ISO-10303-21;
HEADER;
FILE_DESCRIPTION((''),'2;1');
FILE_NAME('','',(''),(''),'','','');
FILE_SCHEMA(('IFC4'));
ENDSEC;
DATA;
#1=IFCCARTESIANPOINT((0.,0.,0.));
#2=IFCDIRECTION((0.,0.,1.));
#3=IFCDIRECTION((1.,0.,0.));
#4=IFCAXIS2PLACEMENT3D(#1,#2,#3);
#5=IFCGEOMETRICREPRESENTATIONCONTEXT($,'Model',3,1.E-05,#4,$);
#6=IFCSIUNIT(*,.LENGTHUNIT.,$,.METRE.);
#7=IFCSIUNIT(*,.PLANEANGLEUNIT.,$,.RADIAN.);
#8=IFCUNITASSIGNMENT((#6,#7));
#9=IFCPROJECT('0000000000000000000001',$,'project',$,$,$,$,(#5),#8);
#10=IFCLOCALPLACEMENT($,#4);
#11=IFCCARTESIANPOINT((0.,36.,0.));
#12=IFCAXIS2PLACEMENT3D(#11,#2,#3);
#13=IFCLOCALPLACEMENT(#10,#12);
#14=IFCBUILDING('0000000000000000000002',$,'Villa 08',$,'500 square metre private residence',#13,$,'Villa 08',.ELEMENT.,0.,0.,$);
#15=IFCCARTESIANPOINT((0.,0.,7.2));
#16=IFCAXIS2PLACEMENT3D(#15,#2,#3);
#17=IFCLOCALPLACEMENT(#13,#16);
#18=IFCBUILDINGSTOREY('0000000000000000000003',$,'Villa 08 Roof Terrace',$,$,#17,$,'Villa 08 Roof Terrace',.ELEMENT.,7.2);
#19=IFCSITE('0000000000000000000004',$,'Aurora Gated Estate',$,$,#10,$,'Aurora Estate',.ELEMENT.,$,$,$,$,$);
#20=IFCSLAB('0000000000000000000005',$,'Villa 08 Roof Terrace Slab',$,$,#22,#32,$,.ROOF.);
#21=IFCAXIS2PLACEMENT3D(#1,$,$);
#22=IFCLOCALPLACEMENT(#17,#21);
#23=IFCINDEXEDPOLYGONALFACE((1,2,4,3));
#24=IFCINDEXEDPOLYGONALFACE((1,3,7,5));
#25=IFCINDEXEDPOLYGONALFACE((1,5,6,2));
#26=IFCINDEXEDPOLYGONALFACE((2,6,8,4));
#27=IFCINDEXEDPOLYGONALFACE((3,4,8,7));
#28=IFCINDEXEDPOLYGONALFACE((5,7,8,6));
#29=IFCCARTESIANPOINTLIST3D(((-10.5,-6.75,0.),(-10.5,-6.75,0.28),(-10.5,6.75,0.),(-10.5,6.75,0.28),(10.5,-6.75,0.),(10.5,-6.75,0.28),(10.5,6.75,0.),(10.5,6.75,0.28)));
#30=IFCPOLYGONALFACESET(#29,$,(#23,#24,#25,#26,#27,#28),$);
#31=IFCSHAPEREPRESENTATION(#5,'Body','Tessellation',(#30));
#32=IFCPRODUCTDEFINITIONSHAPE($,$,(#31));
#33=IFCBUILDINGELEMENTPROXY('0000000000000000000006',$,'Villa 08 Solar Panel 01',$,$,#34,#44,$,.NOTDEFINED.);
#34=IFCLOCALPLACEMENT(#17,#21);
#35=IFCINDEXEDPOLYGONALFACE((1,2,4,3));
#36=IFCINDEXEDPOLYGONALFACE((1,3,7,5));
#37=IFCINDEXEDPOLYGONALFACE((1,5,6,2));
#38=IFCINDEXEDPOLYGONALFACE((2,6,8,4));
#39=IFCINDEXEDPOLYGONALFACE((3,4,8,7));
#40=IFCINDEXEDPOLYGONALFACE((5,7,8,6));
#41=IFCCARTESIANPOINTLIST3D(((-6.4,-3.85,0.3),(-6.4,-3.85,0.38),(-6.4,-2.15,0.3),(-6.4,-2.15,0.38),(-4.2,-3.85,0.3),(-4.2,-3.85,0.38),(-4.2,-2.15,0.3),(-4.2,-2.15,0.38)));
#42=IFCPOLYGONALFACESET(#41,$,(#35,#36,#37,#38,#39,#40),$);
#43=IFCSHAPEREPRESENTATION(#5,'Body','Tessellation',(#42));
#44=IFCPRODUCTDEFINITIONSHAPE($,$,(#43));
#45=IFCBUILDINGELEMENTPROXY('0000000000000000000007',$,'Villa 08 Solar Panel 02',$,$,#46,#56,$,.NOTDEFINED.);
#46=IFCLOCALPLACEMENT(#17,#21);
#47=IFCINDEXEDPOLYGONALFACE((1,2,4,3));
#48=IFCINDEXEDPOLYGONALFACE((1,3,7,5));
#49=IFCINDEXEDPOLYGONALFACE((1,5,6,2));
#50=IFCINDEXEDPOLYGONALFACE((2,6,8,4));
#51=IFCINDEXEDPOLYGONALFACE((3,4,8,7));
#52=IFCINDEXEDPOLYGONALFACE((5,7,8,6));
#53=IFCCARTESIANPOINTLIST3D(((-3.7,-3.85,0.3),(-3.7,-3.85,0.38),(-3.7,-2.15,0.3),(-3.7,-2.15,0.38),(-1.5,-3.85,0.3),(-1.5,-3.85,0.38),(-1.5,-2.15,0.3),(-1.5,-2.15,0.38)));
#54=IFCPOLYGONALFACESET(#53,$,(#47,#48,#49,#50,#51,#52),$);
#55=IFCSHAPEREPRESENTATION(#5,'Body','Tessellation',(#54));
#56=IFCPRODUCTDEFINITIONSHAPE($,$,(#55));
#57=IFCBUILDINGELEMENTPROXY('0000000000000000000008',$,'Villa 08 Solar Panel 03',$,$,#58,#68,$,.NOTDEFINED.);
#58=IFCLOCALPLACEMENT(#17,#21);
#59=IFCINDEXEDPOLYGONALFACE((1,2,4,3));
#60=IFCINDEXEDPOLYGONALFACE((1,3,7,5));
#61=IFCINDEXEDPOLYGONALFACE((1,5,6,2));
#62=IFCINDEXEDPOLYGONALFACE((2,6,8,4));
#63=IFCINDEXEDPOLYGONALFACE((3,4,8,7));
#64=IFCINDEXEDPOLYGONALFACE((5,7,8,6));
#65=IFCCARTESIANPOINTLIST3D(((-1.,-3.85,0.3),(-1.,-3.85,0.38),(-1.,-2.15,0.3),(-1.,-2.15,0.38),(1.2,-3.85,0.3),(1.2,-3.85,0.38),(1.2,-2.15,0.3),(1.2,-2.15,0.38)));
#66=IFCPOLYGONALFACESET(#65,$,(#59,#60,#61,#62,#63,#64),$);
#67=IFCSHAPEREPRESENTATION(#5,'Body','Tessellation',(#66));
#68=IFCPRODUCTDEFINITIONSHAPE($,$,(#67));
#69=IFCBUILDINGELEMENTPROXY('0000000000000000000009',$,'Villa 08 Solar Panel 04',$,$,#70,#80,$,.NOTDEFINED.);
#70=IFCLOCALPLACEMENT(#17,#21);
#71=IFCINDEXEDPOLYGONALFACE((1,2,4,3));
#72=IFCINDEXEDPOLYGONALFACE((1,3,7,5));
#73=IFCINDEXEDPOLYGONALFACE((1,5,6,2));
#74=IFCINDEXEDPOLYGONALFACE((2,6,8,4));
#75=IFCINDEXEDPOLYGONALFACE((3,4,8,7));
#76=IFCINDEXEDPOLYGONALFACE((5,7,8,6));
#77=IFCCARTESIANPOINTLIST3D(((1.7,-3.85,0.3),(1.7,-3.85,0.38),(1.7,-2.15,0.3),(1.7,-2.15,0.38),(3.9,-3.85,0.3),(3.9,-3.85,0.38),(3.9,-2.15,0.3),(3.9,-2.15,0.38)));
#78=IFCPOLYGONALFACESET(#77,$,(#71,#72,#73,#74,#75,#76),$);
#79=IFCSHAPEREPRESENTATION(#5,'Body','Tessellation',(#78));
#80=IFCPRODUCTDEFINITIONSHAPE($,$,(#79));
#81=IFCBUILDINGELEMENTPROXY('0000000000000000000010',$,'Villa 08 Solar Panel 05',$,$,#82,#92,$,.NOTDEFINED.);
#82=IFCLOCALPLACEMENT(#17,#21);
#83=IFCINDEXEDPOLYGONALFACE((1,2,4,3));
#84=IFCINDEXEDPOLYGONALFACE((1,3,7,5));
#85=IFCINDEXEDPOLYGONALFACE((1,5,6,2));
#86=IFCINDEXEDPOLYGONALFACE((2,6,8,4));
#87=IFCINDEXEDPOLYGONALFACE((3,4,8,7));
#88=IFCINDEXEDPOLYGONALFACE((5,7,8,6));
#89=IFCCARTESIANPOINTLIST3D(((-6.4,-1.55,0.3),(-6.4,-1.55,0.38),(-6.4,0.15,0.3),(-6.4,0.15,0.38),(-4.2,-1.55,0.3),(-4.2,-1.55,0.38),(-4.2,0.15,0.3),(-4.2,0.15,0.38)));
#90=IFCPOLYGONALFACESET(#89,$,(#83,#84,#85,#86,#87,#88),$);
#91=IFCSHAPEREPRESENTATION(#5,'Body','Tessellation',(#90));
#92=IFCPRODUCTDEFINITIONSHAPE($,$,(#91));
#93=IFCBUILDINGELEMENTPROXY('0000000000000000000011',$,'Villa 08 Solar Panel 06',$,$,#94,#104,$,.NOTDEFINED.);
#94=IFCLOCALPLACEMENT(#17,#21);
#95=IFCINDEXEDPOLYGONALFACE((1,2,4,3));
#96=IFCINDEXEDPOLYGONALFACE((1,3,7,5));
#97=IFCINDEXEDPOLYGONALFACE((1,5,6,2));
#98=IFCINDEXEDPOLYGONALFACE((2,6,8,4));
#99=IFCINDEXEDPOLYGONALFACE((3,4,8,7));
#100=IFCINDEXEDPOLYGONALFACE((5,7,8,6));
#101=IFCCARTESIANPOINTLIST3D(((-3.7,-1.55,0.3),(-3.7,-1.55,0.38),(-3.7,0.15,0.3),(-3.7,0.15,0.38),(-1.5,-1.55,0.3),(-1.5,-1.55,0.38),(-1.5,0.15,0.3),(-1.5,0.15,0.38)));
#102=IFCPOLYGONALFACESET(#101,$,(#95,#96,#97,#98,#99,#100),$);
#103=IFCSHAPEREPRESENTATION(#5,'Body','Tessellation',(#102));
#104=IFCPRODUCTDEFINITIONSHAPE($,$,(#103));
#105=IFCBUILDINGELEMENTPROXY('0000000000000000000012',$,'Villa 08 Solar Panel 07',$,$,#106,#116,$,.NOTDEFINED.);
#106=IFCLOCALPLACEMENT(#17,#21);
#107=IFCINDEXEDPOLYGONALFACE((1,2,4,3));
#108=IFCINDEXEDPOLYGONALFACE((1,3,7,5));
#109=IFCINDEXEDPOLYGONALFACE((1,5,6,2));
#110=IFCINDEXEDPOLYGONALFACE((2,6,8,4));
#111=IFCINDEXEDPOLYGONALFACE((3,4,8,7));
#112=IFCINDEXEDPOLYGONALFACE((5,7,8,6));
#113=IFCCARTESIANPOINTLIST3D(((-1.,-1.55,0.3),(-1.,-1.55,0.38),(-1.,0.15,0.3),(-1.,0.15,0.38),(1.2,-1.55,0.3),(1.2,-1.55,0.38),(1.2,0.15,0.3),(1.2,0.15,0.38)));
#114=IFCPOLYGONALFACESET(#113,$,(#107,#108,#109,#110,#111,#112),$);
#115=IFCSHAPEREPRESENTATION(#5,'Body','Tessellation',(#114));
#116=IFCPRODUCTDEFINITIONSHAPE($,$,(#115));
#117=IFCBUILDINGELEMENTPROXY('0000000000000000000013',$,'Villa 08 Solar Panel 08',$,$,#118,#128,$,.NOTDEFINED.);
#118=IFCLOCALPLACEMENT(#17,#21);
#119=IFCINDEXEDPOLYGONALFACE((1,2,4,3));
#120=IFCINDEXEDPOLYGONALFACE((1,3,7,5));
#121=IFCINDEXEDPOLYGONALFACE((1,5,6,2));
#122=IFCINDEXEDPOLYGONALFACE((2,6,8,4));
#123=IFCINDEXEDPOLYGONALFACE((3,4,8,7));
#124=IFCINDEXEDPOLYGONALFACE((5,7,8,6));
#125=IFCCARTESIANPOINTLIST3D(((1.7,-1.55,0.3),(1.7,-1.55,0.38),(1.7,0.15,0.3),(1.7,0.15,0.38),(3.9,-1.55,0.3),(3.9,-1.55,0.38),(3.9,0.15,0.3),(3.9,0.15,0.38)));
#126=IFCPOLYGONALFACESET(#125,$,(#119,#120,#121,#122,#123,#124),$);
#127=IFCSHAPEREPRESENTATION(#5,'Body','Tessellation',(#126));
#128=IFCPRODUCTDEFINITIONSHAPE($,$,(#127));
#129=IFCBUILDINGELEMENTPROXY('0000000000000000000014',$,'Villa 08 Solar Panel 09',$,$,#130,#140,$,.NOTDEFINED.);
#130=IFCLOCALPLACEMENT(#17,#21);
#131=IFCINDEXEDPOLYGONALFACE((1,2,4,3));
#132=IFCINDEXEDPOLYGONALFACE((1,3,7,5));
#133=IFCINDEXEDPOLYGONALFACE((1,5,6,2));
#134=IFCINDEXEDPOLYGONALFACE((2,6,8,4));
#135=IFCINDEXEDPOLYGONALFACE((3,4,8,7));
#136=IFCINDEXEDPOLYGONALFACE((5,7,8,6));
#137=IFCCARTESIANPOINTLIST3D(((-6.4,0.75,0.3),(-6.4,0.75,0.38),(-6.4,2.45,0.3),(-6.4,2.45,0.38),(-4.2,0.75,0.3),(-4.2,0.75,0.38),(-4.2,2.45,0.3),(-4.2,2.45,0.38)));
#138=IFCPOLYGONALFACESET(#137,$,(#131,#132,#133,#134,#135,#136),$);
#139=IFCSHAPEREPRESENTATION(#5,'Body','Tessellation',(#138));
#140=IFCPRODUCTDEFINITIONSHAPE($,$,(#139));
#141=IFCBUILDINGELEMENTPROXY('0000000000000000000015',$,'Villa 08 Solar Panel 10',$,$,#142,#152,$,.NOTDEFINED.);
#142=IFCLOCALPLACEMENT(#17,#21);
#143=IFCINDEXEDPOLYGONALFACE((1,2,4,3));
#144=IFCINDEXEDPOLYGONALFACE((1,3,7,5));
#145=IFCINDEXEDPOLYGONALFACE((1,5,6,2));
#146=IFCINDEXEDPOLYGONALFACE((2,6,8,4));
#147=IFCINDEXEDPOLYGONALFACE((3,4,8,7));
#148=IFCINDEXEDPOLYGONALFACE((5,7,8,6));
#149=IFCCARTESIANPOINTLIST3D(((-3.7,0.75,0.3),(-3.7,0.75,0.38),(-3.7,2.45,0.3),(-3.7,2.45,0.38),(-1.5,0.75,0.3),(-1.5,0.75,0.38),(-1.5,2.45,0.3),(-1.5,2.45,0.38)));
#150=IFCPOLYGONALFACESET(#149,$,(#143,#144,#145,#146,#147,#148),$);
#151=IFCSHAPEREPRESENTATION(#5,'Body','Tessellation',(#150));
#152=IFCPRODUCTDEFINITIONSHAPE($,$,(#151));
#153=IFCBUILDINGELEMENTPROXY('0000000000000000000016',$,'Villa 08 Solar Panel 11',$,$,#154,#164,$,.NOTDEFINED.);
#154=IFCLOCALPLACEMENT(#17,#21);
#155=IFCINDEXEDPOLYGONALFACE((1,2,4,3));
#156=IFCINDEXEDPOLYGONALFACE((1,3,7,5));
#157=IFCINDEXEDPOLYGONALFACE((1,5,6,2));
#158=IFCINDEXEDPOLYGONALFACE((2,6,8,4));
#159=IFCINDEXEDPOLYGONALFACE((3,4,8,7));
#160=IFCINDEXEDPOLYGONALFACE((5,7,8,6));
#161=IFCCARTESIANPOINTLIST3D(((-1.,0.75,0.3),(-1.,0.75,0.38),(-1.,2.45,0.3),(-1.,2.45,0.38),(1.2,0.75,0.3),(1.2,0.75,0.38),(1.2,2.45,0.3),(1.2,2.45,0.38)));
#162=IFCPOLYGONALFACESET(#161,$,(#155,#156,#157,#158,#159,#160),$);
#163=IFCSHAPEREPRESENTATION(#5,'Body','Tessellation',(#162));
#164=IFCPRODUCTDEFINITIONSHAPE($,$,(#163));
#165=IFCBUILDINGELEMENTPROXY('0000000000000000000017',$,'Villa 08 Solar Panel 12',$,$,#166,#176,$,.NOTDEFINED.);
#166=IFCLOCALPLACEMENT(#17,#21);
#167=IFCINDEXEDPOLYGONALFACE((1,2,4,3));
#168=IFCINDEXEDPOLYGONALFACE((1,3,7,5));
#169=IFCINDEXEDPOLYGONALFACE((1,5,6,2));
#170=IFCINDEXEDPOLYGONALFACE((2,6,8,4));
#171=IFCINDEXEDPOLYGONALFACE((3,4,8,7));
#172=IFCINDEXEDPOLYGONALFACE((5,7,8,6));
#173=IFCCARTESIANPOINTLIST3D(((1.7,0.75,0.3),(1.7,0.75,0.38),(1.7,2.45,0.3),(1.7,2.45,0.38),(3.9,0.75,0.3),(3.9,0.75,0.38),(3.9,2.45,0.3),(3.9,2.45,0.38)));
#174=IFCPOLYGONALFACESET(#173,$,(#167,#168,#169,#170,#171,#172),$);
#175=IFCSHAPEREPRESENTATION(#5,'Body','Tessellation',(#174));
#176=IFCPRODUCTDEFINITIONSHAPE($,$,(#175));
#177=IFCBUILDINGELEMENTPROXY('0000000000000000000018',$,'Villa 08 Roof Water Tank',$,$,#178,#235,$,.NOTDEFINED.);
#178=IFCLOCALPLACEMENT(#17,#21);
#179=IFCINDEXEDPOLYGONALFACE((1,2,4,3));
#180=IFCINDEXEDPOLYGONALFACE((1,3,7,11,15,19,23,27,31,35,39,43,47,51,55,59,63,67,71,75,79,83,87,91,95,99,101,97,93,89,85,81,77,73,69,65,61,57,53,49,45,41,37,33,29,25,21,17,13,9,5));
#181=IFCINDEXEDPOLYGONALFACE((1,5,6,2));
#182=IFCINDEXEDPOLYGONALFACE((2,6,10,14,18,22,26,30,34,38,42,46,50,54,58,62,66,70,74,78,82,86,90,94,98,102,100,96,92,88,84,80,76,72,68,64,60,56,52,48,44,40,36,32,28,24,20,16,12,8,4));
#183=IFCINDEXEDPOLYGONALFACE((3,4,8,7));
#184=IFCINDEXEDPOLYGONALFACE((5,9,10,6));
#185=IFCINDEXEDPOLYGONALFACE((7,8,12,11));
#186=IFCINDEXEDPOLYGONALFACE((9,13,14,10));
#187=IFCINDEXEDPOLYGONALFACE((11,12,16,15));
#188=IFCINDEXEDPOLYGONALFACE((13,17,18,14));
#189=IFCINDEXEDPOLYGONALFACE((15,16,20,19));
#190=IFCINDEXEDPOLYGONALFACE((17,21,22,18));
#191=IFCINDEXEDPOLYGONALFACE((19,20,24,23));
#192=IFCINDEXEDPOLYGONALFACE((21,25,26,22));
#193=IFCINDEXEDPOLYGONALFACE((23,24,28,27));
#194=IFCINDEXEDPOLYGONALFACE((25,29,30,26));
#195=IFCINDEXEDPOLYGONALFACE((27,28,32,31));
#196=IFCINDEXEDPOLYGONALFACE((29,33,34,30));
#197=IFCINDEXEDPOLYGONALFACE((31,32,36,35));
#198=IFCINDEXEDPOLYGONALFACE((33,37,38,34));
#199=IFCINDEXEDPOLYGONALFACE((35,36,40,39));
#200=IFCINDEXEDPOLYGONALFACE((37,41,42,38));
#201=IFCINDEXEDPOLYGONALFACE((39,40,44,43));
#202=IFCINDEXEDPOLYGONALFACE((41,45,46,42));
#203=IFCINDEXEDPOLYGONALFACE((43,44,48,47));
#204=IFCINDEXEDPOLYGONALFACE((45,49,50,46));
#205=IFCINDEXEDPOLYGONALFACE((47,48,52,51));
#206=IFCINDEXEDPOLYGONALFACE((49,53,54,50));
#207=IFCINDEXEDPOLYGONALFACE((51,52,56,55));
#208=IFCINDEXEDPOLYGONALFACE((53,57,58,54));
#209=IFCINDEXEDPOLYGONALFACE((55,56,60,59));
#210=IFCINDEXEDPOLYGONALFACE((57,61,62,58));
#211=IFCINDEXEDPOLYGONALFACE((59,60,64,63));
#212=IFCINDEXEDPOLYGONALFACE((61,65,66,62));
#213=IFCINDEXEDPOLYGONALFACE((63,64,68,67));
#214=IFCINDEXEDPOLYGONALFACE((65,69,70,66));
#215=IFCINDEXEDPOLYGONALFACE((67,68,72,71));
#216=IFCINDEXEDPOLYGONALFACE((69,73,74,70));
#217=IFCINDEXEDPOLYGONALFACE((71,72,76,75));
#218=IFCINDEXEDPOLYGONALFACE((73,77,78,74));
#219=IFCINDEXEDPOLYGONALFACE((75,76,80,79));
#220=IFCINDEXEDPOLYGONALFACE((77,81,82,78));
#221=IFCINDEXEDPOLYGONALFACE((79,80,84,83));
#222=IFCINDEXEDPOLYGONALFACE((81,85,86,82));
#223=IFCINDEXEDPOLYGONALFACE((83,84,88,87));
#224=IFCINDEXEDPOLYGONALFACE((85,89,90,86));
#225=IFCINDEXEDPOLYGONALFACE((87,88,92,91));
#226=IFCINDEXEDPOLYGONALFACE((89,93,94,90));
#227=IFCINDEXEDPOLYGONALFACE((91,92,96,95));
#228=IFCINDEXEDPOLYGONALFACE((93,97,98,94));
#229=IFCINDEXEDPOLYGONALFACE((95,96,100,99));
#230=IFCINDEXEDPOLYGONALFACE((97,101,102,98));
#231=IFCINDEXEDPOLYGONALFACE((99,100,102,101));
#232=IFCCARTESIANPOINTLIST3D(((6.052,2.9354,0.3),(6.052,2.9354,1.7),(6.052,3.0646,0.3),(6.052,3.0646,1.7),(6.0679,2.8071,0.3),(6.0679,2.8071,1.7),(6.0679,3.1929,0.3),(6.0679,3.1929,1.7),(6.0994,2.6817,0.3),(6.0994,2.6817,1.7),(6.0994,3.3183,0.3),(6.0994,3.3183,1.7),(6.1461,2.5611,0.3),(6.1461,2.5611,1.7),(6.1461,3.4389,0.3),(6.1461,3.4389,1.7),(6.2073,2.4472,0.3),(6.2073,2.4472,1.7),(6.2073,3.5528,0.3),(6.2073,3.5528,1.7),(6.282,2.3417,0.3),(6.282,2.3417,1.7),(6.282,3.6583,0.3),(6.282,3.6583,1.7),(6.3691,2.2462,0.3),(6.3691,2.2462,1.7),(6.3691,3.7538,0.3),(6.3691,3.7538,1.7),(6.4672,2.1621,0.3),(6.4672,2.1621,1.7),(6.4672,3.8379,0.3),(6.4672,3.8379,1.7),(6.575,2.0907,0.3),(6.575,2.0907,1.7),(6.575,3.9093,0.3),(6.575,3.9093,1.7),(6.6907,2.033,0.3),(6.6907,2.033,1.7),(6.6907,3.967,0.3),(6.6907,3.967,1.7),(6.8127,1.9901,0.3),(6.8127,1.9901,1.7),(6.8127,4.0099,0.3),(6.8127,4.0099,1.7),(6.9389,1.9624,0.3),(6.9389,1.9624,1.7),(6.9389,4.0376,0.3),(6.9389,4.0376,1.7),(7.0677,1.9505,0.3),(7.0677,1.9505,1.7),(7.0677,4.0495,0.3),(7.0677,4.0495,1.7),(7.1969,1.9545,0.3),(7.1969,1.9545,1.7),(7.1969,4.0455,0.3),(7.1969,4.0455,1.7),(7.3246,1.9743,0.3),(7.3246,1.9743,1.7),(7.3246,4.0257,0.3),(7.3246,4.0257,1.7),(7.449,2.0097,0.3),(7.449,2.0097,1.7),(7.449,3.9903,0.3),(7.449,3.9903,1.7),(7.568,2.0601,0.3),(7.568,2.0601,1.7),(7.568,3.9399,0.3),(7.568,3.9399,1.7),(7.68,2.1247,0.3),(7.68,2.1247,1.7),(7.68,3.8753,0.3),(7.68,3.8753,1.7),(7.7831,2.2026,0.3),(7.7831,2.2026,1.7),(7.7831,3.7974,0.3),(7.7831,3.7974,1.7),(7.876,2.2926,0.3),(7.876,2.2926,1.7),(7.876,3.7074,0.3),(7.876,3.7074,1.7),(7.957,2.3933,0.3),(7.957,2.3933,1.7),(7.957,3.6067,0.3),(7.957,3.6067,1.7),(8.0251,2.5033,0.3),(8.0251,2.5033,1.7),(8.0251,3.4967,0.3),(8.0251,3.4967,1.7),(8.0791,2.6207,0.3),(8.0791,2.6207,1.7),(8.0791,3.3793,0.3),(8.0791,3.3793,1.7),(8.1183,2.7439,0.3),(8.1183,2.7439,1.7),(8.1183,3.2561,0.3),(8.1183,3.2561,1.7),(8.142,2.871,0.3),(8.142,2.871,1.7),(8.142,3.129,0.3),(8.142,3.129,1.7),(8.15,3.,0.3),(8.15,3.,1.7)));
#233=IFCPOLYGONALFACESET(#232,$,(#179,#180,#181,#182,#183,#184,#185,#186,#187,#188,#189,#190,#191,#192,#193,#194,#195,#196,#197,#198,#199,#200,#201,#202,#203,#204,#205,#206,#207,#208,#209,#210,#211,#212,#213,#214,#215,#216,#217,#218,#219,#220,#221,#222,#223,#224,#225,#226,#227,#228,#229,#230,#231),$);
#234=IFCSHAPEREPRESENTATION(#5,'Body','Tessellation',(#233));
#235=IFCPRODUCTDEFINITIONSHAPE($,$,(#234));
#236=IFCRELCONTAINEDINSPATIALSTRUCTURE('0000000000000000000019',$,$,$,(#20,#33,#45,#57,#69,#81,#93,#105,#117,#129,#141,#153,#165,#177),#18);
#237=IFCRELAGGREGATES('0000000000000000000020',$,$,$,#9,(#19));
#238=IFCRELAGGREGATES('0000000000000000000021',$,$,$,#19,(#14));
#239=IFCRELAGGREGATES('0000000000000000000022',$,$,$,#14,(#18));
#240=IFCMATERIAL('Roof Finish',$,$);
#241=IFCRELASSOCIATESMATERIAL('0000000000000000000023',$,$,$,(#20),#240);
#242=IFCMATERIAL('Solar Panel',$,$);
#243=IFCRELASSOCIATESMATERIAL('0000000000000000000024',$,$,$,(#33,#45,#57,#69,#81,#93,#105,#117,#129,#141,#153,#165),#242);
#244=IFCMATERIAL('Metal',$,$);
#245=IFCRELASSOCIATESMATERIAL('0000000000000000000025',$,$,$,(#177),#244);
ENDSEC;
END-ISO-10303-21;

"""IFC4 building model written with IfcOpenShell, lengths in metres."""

from ifc_helpers import new_model, si_unit, frame, origin_with_axes, origin_2d_with_axis, place, context, project, spatial, rectangle, circle, extrude, material, element, save


model = new_model("IFC4")

# Units and contexts
model_context = context("Model", 3, precision=1e-05, world=origin_with_axes())
ifc_project = project(units=[si_unit("LENGTHUNIT", "METRE"), si_unit("PLANEANGLEUNIT", "RADIAN")], contexts=[model_context])

# Site, building, storey
site_placement = place(None, origin_with_axes())
site = spatial("IfcSite", under=ifc_project, at=site_placement, Name="Aurora Gated Estate", LongName="Aurora Estate", CompositionType="ELEMENT")
building_placement = place(site_placement, frame((0.0, 36.0, 0.0), z_axis=(0.0, 0.0, 1.0), x_axis=(1.0, 0.0, 0.0)))
building = spatial("IfcBuilding", under=site, at=building_placement, Name="Villa 08", ObjectType="500 square metre private residence", LongName="Villa 08", CompositionType="ELEMENT", ElevationOfRefHeight=0.0, ElevationOfTerrain=0.0)
storey_placement = place(building_placement, frame((0.0, 0.0, 7.2), z_axis=(0.0, 0.0, 1.0), x_axis=(1.0, 0.0, 0.0)))
storey = spatial("IfcBuildingStorey", under=building, at=storey_placement, Name="Villa 08 Roof Terrace", LongName="Villa 08 Roof Terrace", CompositionType="ELEMENT", Elevation=7.2)

# Slab
ifc_material_1 = material(Name="Roof Finish")
slab_placement = place(storey_placement, origin_with_axes())
element("IfcSlab", 1, at=slab_placement, inside=storey, material=ifc_material_1, Name="Villa 08 Roof Terrace Slab", PredefinedType="ROOF", context=model_context, shape_type="SweptSolid", body=[
    extrude(rectangle(XDim=21.0, YDim=13.5, at=origin_2d_with_axis()), origin_with_axes(), (0.0, 0.0, 1.0), 0.28),
])

# Building element proxies
ifc_material_2 = material(Name="Solar Panel")
for number, where, z_axis, x_axis, name in (
    (2, (-5.3, -3.0, 0.3), (0.0, 0.0, 1.0), (1.0, 0.0, 0.0), "Villa 08 Solar Panel 01"),
    (3, (-2.6, -3.0, 0.3), (0.0, 0.0, 1.0), (1.0, 0.0, 0.0), "Villa 08 Solar Panel 02"),
    (4, (0.1, -3.0, 0.3), (0.0, 0.0, 1.0), (1.0, 0.0, 0.0), "Villa 08 Solar Panel 03"),
    (5, (2.8, -3.0, 0.3), (0.0, 0.0, 1.0), (1.0, 0.0, 0.0), "Villa 08 Solar Panel 04"),
    (6, (-5.3, -0.7, 0.3), (0.0, 0.0, 1.0), (1.0, 0.0, 0.0), "Villa 08 Solar Panel 05"),
    (7, (-2.6, -0.7, 0.3), (0.0, 0.0, 1.0), (1.0, 0.0, 0.0), "Villa 08 Solar Panel 06"),
    (8, (0.1, -0.7, 0.3), (0.0, 0.0, 1.0), (1.0, 0.0, 0.0), "Villa 08 Solar Panel 07"),
    (9, (2.8, -0.7, 0.3), (0.0, 0.0, 1.0), (1.0, 0.0, 0.0), "Villa 08 Solar Panel 08"),
    (10, (-5.3, 1.6, 0.3), (0.0, 0.0, 1.0), (1.0, 0.0, 0.0), "Villa 08 Solar Panel 09"),
    (11, (-2.6, 1.6, 0.3), (0.0, 0.0, 1.0), (1.0, 0.0, 0.0), "Villa 08 Solar Panel 10"),
    (12, (0.1, 1.6, 0.3), (0.0, 0.0, 1.0), (1.0, 0.0, 0.0), "Villa 08 Solar Panel 11"),
    (13, (2.8, 1.6, 0.3), (0.0, 0.0, 1.0), (1.0, 0.0, 0.0), "Villa 08 Solar Panel 12"),
):
    element("IfcBuildingElementProxy", number, at=place(storey_placement, frame(where, z_axis=z_axis, x_axis=x_axis)), inside=storey, material=ifc_material_2, Name=name, PredefinedType="NOTDEFINED", context=model_context, shape_type="SweptSolid", body=[
        extrude(rectangle(XDim=2.2, YDim=1.7, at=origin_2d_with_axis()), origin_with_axes(), (0.0, 0.0, 1.0), 0.08),
    ])
ifc_material_3 = material(Name="Metal")
proxy_1_placement = place(storey_placement, frame((7.1, 3.0, 0.3), z_axis=(0.0, 0.0, 1.0), x_axis=(1.0, 0.0, 0.0)))
element("IfcBuildingElementProxy", 14, at=proxy_1_placement, inside=storey, material=ifc_material_3, Name="Villa 08 Roof Water Tank", PredefinedType="NOTDEFINED", context=model_context, shape_type="SweptSolid", body=[
    extrude(circle(Radius=1.05, at=origin_2d_with_axis()), origin_with_axes(), (0.0, 0.0, 1.0), 1.4),
])

save(model, "model.ifc")
